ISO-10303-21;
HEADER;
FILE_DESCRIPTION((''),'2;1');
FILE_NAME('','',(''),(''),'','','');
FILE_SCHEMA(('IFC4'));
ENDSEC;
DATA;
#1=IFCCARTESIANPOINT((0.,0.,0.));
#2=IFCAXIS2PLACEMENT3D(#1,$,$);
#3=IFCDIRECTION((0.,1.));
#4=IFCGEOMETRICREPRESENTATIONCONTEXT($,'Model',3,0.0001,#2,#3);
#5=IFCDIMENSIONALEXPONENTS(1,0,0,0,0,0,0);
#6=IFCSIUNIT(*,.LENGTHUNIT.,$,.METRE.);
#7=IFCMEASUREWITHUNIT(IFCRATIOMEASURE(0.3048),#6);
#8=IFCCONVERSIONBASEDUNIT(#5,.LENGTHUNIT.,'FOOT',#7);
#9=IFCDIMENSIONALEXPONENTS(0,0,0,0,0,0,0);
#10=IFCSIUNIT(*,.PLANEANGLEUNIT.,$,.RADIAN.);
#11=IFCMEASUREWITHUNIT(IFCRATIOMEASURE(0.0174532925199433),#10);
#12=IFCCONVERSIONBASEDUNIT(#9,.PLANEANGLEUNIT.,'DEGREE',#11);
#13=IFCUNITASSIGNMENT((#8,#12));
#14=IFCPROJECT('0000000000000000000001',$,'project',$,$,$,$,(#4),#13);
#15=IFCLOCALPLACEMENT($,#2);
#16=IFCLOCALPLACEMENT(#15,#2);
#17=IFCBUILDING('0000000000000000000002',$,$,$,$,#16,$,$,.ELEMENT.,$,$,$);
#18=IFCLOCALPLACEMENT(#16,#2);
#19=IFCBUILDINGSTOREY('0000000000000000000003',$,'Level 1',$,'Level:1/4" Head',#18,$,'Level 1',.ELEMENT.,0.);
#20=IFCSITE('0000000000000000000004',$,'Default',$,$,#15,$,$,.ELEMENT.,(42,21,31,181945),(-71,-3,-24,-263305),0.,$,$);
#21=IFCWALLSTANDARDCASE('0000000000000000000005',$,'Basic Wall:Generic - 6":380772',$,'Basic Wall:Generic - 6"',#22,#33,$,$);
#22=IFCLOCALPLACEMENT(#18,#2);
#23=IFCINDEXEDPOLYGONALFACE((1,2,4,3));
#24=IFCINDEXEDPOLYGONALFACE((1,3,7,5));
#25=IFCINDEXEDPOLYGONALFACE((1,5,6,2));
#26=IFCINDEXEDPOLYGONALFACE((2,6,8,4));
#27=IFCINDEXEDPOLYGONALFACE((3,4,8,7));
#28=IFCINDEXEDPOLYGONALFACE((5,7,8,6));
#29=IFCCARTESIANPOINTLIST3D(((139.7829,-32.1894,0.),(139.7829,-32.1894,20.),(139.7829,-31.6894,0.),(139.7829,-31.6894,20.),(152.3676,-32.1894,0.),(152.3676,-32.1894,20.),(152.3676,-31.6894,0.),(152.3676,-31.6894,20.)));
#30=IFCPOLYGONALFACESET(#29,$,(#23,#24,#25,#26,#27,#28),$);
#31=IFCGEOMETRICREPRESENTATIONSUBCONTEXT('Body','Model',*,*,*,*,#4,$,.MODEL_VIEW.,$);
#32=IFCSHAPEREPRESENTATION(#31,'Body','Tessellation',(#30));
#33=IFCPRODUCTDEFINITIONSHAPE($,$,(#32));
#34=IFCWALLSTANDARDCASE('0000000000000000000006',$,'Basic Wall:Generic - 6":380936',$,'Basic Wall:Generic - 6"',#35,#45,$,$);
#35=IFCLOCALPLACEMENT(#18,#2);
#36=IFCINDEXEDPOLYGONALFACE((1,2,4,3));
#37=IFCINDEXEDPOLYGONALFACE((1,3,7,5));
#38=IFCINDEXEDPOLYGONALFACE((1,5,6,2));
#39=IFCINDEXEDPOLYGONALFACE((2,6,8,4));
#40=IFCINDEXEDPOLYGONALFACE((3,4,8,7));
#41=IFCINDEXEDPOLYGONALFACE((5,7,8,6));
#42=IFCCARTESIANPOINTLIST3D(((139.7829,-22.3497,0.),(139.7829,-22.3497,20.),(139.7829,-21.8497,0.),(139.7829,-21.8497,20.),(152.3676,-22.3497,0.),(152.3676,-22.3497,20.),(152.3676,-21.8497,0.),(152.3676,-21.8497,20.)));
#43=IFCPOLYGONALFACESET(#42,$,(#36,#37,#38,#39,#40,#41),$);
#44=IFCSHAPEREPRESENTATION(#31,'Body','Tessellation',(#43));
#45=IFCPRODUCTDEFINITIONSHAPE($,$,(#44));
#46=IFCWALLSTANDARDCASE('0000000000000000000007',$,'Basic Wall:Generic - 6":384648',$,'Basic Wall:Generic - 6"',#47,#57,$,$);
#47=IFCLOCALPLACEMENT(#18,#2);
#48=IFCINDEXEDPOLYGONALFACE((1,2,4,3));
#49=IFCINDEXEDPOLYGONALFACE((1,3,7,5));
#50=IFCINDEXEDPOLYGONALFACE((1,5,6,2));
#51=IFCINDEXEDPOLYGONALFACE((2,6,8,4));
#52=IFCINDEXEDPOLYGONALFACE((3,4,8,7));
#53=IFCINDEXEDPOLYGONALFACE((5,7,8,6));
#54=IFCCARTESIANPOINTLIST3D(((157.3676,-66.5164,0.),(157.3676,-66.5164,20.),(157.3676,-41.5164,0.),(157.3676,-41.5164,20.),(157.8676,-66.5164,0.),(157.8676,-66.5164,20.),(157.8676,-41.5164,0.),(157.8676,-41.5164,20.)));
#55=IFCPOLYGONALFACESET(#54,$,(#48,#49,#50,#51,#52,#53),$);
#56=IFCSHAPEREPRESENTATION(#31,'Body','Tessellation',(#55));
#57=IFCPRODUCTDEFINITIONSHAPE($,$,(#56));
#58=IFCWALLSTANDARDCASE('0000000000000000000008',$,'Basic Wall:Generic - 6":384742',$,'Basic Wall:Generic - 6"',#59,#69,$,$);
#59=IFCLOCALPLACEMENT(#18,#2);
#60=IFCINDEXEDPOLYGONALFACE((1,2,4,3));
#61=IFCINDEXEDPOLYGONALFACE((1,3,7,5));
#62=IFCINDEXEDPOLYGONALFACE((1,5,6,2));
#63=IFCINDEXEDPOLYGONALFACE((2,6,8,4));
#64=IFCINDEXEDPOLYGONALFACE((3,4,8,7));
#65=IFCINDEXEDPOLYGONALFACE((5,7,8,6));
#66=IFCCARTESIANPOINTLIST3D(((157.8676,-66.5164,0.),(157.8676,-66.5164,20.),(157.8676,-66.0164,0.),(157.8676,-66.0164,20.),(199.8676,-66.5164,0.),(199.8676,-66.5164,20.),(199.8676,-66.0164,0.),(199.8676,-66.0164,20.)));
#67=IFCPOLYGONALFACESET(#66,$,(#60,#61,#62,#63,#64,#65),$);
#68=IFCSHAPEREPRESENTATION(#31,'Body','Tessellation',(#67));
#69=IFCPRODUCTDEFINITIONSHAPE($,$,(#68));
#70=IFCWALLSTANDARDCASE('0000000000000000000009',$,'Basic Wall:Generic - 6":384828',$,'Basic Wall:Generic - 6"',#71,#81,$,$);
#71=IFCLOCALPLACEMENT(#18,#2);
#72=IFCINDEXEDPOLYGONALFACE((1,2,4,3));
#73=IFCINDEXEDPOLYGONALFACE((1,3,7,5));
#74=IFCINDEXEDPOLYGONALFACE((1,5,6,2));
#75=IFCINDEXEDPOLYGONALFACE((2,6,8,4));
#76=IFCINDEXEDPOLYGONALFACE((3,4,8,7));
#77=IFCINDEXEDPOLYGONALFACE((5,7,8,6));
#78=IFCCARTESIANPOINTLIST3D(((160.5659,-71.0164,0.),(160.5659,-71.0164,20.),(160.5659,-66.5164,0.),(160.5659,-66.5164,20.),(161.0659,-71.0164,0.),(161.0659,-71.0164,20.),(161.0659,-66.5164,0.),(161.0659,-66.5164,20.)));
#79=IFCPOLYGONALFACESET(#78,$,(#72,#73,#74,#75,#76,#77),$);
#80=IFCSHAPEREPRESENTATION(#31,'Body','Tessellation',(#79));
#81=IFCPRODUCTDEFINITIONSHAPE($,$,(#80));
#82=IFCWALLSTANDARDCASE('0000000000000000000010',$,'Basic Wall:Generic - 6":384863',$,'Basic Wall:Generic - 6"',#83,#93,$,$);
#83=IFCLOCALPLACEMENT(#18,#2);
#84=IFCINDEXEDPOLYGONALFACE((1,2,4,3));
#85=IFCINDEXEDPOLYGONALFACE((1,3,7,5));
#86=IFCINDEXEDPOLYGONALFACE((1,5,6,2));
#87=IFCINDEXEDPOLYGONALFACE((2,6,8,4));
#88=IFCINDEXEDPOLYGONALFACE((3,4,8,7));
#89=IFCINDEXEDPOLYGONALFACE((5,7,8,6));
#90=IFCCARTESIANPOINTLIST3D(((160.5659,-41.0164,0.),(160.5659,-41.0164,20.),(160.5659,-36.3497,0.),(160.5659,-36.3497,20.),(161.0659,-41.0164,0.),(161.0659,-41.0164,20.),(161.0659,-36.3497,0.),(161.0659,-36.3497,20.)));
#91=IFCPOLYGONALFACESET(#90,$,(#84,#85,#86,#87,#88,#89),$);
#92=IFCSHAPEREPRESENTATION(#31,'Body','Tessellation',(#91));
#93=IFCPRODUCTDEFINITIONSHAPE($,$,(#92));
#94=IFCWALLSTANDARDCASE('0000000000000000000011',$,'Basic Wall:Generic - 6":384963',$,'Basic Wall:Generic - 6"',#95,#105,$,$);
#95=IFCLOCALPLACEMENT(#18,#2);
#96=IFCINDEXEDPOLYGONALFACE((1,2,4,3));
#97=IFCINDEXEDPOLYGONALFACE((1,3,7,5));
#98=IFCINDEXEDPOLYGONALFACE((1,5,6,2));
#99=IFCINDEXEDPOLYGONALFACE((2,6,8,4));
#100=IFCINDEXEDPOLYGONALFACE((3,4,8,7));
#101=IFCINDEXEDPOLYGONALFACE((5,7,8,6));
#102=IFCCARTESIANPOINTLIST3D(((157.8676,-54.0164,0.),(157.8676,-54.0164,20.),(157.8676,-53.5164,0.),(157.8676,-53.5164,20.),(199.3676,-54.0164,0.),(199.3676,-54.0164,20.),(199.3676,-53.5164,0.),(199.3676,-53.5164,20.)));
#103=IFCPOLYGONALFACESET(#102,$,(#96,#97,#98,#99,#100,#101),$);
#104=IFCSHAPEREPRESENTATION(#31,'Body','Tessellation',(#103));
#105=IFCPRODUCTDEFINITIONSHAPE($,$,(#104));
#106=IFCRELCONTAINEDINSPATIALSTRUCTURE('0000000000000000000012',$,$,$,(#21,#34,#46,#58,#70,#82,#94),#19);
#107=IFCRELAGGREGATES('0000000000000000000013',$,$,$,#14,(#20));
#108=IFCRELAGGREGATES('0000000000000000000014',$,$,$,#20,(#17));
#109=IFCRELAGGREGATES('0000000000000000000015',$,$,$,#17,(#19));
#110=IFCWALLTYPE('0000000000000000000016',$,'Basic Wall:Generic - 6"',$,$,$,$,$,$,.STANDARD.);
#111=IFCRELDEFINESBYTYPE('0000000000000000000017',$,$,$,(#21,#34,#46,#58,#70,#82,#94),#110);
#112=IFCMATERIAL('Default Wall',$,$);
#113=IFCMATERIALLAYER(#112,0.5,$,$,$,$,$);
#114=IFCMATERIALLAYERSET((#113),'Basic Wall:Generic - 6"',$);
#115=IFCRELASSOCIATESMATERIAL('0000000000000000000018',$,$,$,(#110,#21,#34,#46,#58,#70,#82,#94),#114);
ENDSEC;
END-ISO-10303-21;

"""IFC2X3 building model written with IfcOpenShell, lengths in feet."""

from ifc_helpers import new_model, entity, si_unit, converted_unit, direction, frame, frame_2d, origin, place, context, subcontext, project, spatial, rectangle, extrude, material, layer, layer_set, layer_usage, type_object, element, save


model = new_model("IFC2X3")

# Units and contexts
model_context = context("Model", 3, precision=0.0001, world=origin(), true_north=direction((0.0, 1.0)))
body_context = subcontext(model_context, "Body", "Model", "MODEL_VIEW")
ifc_project = project(units=[converted_unit("LENGTHUNIT", "FOOT", entity("IfcRatioMeasure", 0.3048), si_unit("LENGTHUNIT", "METRE"), dimensions=[1, 0, 0, 0, 0, 0, 0]), converted_unit("PLANEANGLEUNIT", "DEGREE", entity("IfcRatioMeasure", 0.0174532925199433), si_unit("PLANEANGLEUNIT", "RADIAN"), dimensions=[0, 0, 0, 0, 0, 0, 0])], contexts=[model_context])

# Site, building, storey
site_placement = place(None, origin())
site = spatial("IfcSite", under=ifc_project, at=site_placement, Name="Default", CompositionType="ELEMENT", RefLatitude=(42, 21, 31, 181945), RefLongitude=(-71, -3, -24, -263305), RefElevation=0.0)
building_placement = place(site_placement, origin())
building = spatial("IfcBuilding", under=site, at=building_placement, CompositionType="ELEMENT")
storey_placement = place(building_placement, origin())
storey = spatial("IfcBuildingStorey", under=building, at=storey_placement, Name="Level 1", ObjectType="Level:1/4\" Head", LongName="Level 1", CompositionType="ELEMENT", Elevation=0.0)

# Walls
ifc_material = material(Name="Default Wall")
ifc_layer = layer(ifc_material, 0.5)
ifc_layer_set = layer_set([ifc_layer], Name="Basic Wall:Generic - 6\"")
wall_type = type_object("IfcWallType", Name="Basic Wall:Generic - 6\"", PredefinedType="STANDARD", material=ifc_layer_set)
ifc_layer_usage_1 = layer_usage(ifc_layer_set, "AXIS2", "NEGATIVE", 0.25)
wall_1_placement = place(storey_placement, frame((152.3676, -31.9394, 0.0), z_axis=(0.0, 0.0, 1.0), x_axis=(-1.0, 0.0, 0.0)))
element("IfcWallStandardCase", 1, at=wall_1_placement, inside=storey, type_object=wall_type, material=ifc_layer_usage_1, Name="Basic Wall:Generic - 6\":380772", ObjectType="Basic Wall:Generic - 6\"", context=body_context, shape_type="SweptSolid", body=[
    extrude(rectangle(XDim=12.5847, YDim=0.5, at=frame_2d((6.2924, 0.0), x_axis=(-1.0, 0.0))), origin(), (0.0, 0.0, 1.0), 20.0),
])
ifc_layer_usage_2 = layer_usage(ifc_layer_set, "AXIS2", "NEGATIVE", 0.25)
wall_2_placement = place(storey_placement, frame((152.3676, -22.0997, 0.0), z_axis=(0.0, 0.0, 1.0), x_axis=(-1.0, 0.0, 0.0)))
element("IfcWallStandardCase", 2, at=wall_2_placement, inside=storey, type_object=wall_type, material=ifc_layer_usage_2, Name="Basic Wall:Generic - 6\":380936", ObjectType="Basic Wall:Generic - 6\"", context=body_context, shape_type="SweptSolid", body=[
    extrude(rectangle(XDim=12.5847, YDim=0.5, at=frame_2d((6.2924, 0.0), x_axis=(-1.0, 0.0))), origin(), (0.0, 0.0, 1.0), 20.0),
])
ifc_layer_usage_3 = layer_usage(ifc_layer_set, "AXIS2", "NEGATIVE", 0.25)
wall_3_placement = place(storey_placement, frame((157.6176, -41.5164, 0.0), z_axis=(0.0, 0.0, 1.0), x_axis=(0.0, -1.0, 0.0)))
element("IfcWallStandardCase", 3, at=wall_3_placement, inside=storey, type_object=wall_type, material=ifc_layer_usage_3, Name="Basic Wall:Generic - 6\":384648", ObjectType="Basic Wall:Generic - 6\"", context=body_context, shape_type="SweptSolid", body=[
    extrude(rectangle(XDim=25.0, YDim=0.5, at=frame_2d((12.5, 0.0), x_axis=(-1.0, 0.0))), origin(), (0.0, 0.0, 1.0), 20.0),
])
ifc_layer_usage_4 = layer_usage(ifc_layer_set, "AXIS2", "NEGATIVE", 0.25)
wall_4_placement = place(storey_placement, frame((157.8676, -66.2664, 0.0)))
element("IfcWallStandardCase", 4, at=wall_4_placement, inside=storey, type_object=wall_type, material=ifc_layer_usage_4, Name="Basic Wall:Generic - 6\":384742", ObjectType="Basic Wall:Generic - 6\"", context=body_context, shape_type="SweptSolid", body=[
    extrude(rectangle(XDim=42.0, YDim=0.5, at=frame_2d((21.0, 0.0), x_axis=(-1.0, 0.0))), origin(), (0.0, 0.0, 1.0), 20.0),
])
ifc_layer_usage_5 = layer_usage(ifc_layer_set, "AXIS2", "NEGATIVE", 0.25)
wall_5_placement = place(storey_placement, frame((160.8159, -71.0164, 0.0), z_axis=(0.0, 0.0, 1.0), x_axis=(0.0, 1.0, 0.0)))
element("IfcWallStandardCase", 5, at=wall_5_placement, inside=storey, type_object=wall_type, material=ifc_layer_usage_5, Name="Basic Wall:Generic - 6\":384828", ObjectType="Basic Wall:Generic - 6\"", context=body_context, shape_type="SweptSolid", body=[
    extrude(rectangle(XDim=4.5, YDim=0.5, at=frame_2d((2.25, 0.0), x_axis=(-1.0, 0.0))), origin(), (0.0, 0.0, 1.0), 20.0),
])
ifc_layer_usage_6 = layer_usage(ifc_layer_set, "AXIS2", "NEGATIVE", 0.25)
wall_6_placement = place(storey_placement, frame((160.8159, -36.3497, 0.0), z_axis=(0.0, 0.0, 1.0), x_axis=(0.0, -1.0, 0.0)))
element("IfcWallStandardCase", 6, at=wall_6_placement, inside=storey, type_object=wall_type, material=ifc_layer_usage_6, Name="Basic Wall:Generic - 6\":384863", ObjectType="Basic Wall:Generic - 6\"", context=body_context, shape_type="SweptSolid", body=[
    extrude(rectangle(XDim=4.6667, YDim=0.5, at=frame_2d((2.3333, 0.0), x_axis=(-1.0, 0.0))), origin(), (0.0, 0.0, 1.0), 20.0),
])
ifc_layer_usage_7 = layer_usage(ifc_layer_set, "AXIS2", "NEGATIVE", 0.25)
wall_7_placement = place(storey_placement, frame((157.8676, -53.7664, 0.0)))
element("IfcWallStandardCase", 7, at=wall_7_placement, inside=storey, type_object=wall_type, material=ifc_layer_usage_7, Name="Basic Wall:Generic - 6\":384963", ObjectType="Basic Wall:Generic - 6\"", context=body_context, shape_type="SweptSolid", body=[
    extrude(rectangle(XDim=41.5, YDim=0.5, at=frame_2d((20.75, 0.0), x_axis=(-1.0, 0.0))), origin(), (0.0, 0.0, 1.0), 20.0),
])

save(model, "model.ifc")
